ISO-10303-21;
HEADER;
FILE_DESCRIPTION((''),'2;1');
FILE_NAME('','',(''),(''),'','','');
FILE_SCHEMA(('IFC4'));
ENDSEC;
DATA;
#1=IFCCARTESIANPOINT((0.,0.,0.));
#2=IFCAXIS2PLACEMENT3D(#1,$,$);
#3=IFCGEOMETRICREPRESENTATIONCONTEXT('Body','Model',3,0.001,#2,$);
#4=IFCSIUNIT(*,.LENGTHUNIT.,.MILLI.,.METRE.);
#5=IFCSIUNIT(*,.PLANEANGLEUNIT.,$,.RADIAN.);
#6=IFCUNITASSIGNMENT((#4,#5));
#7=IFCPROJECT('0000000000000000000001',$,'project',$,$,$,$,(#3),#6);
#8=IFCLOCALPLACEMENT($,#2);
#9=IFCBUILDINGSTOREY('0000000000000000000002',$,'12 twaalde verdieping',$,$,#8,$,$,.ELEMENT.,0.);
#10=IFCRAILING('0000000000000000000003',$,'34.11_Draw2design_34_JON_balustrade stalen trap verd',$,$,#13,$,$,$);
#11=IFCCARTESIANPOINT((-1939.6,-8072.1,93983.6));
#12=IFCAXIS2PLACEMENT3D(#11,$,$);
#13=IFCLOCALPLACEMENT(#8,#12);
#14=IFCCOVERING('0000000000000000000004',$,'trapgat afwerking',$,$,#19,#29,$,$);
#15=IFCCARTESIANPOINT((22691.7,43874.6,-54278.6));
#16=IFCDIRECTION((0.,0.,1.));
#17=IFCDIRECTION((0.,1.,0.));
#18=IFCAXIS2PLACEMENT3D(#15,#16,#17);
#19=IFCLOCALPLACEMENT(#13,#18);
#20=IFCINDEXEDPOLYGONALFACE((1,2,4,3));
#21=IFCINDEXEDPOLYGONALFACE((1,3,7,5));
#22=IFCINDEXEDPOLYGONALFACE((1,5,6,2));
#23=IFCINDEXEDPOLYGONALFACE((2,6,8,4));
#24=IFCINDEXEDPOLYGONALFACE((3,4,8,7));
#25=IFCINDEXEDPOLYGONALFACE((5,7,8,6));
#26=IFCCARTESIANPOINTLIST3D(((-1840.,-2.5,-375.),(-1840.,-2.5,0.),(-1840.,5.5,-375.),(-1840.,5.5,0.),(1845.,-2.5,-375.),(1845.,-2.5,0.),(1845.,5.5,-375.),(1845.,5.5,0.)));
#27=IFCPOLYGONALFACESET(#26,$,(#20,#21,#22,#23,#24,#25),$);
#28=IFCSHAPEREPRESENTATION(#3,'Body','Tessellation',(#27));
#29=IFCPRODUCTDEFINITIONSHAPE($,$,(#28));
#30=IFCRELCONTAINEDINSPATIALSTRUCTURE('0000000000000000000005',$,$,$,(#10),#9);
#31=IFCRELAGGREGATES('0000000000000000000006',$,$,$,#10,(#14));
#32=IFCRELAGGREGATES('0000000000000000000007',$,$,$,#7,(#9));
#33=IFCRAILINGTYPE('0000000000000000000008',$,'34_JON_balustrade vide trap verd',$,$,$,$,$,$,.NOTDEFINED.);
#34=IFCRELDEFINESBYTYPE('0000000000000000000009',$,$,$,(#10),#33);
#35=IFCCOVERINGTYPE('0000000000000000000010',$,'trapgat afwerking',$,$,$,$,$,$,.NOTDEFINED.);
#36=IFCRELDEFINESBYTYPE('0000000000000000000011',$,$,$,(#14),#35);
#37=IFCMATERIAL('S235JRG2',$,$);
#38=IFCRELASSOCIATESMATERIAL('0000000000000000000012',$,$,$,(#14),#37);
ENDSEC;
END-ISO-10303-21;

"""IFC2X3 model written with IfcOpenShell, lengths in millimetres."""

from ifc_helpers import new_model, si_unit, frame, origin, place, context, project, spatial, polyline, outline, extrude, source, transform, mapped, material, type_object, element, aggregate, save


model = new_model("IFC2X3")

# Units and contexts
model_context = context("Model", 3, precision=0.001, world=origin(), identifier="Body")
ifc_project = project(units=[si_unit("LENGTHUNIT", "METRE", prefix="MILLI"), si_unit("PLANEANGLEUNIT", "RADIAN")], contexts=[model_context])

# Storey
storey_placement = place(None, origin())
storey = spatial("IfcBuildingStorey", under=ifc_project, at=storey_placement, Name="12 twaalde verdieping", CompositionType="ELEMENT", Elevation=0.0)

# Railing, covering
railing_type = type_object("IfcRailingType", Name="34_JON_balustrade vide trap verd")
railing_placement = place(storey_placement, frame((-1939.6, -8072.1, 93983.6)))
railing = element("IfcRailing", 1, at=railing_placement, inside=storey, type_object=railing_type, Name="34.11_Draw2design_34_JON_balustrade stalen trap verd")
ifc_material_1 = material(Name="S235JRG2")
covering_type = type_object("IfcCoveringType", Name="trapgat afwerking")
shared_shape_1 = source(origin(), model_context, "Body", "SweptSolid", [
    extrude(outline(polyline([(-1840.0, -2.5), (1845.0, -2.5), (1845.0, 5.5), (-1840.0, 5.5), (-1840.0, -2.5)])), origin(), (0.0, 0.0, -1.0), 375.0),
])
covering_placement = place(railing_placement, frame((22691.7, 43874.6, -54278.6), z_axis=(0.0, 0.0, 1.0), x_axis=(0.0, 1.0, 0.0)))
covering = element("IfcCovering", 2, at=covering_placement, type_object=covering_type, material=ifc_material_1, Name="trapgat afwerking", context=model_context, shape_type="MappedRepresentation", body=[
    mapped(shared_shape_1, transform((0.0, 0.0, 0.0), scale=1.0)),
])
aggregate(railing, [covering])

save(model, "model.ifc")
